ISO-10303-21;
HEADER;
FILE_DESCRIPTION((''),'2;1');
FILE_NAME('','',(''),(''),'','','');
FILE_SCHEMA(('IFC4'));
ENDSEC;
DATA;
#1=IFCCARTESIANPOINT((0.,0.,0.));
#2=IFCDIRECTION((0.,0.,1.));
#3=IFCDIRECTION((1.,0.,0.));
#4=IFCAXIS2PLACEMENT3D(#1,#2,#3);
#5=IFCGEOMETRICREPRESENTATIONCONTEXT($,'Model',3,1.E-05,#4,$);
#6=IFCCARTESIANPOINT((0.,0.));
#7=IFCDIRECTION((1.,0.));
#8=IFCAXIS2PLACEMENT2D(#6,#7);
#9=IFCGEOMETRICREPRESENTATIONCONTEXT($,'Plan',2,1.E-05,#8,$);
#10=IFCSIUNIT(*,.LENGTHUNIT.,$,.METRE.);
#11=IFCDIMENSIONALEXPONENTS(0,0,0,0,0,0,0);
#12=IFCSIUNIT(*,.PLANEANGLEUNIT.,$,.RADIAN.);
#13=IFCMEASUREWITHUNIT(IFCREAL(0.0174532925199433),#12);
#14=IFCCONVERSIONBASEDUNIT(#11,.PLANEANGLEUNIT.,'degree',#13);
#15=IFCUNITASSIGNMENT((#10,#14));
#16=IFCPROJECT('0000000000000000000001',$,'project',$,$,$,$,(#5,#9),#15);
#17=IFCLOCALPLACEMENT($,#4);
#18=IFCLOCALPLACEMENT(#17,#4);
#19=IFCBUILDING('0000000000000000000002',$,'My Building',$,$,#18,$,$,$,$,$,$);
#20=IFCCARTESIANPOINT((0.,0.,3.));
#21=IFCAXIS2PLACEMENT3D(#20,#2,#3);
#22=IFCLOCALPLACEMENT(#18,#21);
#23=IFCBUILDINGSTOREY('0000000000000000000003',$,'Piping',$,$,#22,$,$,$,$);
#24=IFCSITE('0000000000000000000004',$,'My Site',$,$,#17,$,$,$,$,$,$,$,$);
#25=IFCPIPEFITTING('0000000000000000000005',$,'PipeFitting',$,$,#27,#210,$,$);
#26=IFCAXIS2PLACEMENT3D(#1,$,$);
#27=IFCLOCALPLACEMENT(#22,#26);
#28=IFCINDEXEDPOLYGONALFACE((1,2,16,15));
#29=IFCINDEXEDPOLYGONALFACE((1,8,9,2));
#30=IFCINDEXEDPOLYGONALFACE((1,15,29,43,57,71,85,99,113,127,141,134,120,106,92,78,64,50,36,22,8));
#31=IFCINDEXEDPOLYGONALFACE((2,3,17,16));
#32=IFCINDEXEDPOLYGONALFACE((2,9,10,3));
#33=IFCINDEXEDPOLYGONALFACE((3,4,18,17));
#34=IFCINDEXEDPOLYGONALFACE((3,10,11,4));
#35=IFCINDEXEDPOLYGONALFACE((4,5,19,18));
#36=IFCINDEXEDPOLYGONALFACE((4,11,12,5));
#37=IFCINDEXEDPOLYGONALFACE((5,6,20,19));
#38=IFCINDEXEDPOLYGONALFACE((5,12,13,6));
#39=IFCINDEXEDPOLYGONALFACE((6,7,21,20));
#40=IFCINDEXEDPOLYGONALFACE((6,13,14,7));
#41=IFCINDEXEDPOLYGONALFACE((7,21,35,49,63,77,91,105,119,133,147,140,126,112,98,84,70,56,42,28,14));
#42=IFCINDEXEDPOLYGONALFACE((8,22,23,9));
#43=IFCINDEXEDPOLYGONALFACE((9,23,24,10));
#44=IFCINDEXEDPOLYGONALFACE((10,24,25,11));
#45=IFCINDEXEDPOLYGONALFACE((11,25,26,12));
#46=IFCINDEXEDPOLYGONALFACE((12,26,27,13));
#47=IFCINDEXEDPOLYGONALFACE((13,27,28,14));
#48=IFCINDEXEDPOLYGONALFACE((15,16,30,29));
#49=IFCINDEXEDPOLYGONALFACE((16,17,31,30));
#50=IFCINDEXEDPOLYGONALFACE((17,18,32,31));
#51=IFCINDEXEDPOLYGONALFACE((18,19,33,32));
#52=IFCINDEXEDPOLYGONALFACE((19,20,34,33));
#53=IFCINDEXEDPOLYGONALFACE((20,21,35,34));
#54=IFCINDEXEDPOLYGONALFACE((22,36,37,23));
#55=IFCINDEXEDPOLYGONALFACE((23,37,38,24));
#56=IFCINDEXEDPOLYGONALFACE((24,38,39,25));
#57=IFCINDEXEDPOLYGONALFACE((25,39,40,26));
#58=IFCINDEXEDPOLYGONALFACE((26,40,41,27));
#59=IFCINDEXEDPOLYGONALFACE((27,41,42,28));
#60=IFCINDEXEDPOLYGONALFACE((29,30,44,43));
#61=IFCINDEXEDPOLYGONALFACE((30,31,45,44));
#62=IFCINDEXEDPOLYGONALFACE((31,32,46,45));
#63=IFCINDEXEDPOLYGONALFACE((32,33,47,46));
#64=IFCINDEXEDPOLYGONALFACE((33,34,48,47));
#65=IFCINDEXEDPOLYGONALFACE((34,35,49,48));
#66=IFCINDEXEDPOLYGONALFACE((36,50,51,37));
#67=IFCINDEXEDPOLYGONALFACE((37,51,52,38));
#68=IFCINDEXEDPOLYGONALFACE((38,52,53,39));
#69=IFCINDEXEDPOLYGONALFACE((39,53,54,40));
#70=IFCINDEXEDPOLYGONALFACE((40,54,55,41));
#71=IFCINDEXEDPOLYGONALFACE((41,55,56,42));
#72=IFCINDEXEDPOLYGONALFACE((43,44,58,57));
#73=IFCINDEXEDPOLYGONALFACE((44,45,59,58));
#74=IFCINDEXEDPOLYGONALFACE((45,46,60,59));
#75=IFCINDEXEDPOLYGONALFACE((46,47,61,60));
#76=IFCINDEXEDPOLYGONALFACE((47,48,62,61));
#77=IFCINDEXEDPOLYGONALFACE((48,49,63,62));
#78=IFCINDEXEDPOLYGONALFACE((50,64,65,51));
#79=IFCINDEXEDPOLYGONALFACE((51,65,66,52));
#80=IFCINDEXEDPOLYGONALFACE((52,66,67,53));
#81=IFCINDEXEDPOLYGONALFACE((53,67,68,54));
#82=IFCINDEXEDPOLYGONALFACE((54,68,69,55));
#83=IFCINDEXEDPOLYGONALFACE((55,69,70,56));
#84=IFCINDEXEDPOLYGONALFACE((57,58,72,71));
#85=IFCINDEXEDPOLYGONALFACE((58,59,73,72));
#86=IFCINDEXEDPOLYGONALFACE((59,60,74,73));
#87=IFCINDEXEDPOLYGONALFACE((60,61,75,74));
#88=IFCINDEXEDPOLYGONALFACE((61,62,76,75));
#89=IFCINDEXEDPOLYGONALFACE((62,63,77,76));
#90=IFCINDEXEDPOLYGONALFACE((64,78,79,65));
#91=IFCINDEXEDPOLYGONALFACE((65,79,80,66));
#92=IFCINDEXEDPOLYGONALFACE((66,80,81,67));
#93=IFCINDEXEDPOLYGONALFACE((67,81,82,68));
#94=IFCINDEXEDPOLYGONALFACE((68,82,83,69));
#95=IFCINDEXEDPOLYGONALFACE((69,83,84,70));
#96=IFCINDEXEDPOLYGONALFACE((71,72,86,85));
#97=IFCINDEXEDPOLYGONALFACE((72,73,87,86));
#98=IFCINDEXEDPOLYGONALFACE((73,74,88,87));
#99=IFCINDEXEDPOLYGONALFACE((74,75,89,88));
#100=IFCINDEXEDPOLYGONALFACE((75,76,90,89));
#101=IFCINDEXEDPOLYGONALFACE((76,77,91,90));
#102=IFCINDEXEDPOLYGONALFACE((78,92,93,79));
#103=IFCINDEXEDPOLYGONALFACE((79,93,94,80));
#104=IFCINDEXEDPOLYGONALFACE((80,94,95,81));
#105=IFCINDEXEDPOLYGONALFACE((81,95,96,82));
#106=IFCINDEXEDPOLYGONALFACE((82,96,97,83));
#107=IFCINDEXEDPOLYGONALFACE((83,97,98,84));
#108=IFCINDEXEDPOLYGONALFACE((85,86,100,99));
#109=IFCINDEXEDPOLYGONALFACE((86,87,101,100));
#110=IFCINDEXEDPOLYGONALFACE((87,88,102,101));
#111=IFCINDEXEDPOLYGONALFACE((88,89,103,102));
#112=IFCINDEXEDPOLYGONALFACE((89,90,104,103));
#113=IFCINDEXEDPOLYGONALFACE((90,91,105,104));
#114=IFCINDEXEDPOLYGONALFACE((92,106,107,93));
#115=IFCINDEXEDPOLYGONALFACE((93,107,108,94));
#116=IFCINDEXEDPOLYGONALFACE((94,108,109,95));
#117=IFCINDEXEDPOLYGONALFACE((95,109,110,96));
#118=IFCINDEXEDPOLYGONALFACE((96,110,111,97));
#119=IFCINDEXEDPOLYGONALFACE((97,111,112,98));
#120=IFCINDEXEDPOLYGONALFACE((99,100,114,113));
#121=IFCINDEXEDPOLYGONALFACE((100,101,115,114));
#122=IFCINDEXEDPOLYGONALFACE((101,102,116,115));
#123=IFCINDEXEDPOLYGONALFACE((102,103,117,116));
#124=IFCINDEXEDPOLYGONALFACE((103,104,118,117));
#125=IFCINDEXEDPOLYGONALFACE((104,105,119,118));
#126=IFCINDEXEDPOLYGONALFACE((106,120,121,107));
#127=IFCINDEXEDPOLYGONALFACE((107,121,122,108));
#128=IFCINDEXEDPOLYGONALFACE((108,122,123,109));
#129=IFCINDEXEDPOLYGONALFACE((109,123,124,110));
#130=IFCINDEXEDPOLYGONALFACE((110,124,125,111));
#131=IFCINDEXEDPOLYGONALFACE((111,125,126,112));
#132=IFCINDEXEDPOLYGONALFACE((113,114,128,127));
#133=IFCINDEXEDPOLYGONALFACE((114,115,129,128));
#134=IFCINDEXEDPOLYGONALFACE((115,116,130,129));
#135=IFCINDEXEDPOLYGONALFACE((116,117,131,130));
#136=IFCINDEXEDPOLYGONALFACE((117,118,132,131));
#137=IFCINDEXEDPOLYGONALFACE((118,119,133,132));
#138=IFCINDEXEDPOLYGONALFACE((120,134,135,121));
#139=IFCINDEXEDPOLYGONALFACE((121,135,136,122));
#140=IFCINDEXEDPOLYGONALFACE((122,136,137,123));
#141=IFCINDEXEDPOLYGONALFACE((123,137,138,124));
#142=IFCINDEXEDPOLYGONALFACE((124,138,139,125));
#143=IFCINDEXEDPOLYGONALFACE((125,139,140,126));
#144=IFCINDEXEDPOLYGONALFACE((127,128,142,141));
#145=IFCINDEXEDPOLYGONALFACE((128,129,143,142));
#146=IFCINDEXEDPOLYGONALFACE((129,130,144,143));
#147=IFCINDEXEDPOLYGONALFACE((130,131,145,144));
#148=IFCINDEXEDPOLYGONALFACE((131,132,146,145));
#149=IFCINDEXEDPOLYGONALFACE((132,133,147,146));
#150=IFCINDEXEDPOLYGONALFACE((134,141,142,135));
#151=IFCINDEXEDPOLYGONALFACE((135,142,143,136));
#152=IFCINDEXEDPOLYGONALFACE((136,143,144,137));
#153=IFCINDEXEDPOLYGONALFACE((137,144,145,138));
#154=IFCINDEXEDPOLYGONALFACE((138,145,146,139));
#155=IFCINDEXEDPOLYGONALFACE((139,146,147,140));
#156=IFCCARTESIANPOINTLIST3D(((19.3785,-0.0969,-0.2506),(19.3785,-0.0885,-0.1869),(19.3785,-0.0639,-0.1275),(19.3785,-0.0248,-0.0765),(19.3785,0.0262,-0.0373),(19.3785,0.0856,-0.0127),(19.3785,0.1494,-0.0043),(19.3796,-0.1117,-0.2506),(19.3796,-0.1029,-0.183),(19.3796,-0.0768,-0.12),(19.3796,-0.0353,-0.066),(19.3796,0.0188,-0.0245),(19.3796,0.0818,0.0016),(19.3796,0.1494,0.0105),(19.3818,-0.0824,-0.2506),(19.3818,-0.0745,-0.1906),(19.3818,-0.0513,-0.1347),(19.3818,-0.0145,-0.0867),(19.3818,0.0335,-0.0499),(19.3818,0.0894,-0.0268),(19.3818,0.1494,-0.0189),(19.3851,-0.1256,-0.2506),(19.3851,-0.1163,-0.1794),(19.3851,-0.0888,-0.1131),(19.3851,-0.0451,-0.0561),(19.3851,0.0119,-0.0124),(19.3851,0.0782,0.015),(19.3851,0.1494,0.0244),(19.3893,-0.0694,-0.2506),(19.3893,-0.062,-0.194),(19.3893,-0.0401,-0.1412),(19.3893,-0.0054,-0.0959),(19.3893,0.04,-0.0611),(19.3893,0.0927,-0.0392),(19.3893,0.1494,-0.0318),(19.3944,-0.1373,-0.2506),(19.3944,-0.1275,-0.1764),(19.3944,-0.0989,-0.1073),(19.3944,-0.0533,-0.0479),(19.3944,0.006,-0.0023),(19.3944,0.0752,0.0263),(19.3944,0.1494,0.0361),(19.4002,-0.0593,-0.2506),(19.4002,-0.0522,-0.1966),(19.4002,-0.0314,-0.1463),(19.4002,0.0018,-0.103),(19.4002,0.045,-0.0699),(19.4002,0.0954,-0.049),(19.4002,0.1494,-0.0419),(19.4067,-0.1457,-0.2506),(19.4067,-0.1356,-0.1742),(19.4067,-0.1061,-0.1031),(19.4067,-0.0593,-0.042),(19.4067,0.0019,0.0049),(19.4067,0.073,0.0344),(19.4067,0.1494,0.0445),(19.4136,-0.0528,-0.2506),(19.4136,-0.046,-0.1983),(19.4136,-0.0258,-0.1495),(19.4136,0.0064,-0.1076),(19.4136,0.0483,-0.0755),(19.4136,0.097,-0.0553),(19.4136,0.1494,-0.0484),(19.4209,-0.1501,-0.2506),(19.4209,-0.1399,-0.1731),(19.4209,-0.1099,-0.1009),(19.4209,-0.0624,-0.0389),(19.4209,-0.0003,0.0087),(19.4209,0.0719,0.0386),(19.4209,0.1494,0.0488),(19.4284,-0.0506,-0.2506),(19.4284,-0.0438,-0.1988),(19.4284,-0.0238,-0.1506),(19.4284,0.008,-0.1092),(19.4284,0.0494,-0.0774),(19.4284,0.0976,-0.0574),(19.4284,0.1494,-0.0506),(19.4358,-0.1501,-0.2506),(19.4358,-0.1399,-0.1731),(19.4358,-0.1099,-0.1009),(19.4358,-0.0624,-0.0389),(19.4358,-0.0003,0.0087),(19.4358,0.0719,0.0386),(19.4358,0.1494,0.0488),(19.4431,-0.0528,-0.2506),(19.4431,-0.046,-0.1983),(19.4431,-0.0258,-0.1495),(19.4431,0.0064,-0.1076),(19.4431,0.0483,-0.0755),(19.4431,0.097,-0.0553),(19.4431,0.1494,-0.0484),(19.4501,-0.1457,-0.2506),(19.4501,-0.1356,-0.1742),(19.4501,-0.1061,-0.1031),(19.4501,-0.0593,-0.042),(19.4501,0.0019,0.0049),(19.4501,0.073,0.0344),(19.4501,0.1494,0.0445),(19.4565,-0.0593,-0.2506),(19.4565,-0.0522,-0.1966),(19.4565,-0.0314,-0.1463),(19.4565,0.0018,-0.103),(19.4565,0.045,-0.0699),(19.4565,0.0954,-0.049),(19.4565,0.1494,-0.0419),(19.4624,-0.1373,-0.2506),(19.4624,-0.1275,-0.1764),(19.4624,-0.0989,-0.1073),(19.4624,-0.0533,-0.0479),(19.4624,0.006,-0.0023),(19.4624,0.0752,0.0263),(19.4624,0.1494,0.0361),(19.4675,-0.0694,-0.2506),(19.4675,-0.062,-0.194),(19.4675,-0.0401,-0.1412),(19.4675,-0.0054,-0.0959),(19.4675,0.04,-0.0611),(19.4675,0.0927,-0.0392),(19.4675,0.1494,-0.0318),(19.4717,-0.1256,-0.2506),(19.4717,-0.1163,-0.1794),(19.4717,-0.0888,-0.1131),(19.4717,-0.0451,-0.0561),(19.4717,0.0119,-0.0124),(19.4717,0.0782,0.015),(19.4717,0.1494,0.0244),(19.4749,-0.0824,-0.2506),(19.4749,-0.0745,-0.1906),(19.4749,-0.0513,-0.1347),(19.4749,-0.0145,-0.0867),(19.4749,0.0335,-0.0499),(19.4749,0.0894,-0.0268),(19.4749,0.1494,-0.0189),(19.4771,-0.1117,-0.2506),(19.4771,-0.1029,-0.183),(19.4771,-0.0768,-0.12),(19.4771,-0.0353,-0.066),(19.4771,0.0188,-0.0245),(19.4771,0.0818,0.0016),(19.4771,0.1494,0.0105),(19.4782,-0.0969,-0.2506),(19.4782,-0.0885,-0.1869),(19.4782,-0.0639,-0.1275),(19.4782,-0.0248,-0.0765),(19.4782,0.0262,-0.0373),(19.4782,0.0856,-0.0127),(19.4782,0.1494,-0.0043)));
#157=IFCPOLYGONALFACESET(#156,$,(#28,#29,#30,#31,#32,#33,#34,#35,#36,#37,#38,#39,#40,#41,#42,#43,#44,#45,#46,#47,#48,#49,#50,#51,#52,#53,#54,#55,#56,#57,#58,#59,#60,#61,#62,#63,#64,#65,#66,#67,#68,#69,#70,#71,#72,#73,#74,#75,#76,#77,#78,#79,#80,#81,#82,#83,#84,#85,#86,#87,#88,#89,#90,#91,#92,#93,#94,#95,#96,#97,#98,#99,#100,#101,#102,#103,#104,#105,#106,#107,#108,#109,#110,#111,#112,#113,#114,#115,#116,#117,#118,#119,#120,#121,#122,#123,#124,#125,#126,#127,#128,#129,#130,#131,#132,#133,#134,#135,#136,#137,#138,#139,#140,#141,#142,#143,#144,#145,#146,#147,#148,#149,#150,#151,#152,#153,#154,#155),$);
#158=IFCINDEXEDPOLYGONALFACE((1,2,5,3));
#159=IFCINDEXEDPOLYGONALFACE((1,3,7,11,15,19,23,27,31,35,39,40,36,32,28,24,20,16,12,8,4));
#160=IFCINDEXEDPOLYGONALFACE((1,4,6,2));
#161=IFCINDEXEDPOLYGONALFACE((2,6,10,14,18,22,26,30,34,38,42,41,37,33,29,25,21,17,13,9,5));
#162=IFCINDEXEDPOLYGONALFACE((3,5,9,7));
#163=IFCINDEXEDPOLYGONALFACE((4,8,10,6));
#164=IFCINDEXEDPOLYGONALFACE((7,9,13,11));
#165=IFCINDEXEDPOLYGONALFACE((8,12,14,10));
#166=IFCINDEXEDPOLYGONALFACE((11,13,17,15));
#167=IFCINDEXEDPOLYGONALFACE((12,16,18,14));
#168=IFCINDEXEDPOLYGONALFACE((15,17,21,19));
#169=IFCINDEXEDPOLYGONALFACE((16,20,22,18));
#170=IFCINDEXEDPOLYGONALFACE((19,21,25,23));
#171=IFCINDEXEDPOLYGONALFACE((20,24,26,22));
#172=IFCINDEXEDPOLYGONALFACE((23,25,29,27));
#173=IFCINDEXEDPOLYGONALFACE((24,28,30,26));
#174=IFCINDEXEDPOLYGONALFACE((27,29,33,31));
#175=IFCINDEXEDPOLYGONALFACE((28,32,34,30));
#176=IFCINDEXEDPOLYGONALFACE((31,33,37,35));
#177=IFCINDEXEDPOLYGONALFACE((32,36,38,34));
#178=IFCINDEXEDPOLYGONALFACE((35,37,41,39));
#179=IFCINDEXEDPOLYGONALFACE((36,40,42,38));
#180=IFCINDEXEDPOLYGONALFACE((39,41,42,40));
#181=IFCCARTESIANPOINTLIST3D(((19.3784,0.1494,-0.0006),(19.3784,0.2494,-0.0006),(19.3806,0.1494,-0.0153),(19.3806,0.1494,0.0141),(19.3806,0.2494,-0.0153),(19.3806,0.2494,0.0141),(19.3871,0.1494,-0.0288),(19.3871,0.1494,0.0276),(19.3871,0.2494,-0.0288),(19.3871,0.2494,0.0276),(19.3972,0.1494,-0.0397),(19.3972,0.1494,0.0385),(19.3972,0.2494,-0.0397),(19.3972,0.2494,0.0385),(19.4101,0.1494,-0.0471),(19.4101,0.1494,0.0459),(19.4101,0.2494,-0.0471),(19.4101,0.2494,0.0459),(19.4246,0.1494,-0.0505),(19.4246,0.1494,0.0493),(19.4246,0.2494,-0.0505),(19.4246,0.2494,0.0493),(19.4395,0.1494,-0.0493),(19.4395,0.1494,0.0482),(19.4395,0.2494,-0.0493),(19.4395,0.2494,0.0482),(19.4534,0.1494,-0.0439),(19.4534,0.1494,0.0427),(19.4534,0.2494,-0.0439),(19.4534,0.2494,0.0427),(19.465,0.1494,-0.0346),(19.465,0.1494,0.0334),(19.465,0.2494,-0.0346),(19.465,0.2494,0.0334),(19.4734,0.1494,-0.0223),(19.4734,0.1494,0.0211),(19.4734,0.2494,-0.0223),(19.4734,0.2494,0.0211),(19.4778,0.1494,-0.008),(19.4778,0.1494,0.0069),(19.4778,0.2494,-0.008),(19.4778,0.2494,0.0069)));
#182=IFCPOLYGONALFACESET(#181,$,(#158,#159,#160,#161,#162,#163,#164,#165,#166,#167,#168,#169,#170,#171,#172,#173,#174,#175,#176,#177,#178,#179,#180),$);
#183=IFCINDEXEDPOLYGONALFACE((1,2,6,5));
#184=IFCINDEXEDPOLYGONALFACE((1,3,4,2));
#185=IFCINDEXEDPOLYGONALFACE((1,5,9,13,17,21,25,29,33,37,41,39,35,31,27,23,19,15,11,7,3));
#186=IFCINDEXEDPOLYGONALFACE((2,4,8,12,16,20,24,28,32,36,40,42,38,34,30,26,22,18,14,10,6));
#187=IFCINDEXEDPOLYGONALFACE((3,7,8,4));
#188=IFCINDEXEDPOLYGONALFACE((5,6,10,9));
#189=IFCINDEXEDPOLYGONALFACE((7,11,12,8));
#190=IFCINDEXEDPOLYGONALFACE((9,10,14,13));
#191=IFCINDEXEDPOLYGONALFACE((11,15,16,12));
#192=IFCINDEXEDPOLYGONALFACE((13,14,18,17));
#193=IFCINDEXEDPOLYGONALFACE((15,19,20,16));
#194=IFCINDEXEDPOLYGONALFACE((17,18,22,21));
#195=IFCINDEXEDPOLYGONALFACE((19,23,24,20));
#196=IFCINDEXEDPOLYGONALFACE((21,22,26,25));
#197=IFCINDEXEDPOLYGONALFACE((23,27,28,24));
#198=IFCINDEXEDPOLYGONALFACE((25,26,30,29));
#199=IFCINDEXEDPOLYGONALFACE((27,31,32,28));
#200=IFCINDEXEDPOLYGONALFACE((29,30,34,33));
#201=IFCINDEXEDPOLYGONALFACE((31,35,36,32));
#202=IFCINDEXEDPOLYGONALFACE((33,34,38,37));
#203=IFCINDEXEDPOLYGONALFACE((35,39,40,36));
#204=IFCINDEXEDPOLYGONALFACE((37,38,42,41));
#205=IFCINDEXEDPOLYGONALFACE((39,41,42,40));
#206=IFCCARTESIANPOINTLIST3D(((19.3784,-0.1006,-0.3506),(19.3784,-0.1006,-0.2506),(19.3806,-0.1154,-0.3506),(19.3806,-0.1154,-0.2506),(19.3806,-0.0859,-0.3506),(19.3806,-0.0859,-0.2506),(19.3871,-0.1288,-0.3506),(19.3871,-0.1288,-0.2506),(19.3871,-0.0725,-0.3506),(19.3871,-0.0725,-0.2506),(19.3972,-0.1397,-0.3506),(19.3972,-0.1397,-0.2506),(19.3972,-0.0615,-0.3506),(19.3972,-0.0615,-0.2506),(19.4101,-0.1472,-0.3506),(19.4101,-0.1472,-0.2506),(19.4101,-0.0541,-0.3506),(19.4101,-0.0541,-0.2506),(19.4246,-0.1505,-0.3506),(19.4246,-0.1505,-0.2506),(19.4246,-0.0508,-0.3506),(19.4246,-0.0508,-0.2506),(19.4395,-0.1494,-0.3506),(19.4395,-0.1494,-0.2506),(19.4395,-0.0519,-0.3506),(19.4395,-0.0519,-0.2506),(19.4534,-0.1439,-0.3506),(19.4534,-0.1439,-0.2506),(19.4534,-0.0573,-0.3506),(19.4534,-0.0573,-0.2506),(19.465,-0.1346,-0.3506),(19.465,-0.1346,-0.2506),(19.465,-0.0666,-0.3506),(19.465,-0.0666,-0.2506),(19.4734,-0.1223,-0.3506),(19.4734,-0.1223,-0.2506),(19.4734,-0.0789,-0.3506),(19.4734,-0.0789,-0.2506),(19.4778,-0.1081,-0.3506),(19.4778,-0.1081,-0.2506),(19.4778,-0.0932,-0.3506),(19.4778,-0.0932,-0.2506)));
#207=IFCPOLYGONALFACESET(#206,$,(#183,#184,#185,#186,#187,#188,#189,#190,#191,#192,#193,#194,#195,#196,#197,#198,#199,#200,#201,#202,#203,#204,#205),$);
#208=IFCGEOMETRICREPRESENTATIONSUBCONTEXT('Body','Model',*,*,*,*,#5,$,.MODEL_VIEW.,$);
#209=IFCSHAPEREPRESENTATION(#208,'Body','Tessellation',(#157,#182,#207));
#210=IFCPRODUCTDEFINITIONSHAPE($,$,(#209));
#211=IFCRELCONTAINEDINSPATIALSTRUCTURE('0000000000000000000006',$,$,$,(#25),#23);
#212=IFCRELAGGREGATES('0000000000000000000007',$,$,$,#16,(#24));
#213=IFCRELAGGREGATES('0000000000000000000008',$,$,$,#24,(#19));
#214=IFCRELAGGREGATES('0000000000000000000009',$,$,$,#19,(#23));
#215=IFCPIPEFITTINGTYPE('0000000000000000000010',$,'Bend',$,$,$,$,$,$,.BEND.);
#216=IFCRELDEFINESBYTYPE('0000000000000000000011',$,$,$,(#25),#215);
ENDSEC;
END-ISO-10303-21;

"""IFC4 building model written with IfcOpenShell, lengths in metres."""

from ifc_helpers import new_model, entity, si_unit, converted_unit, frame, origin_with_axes, origin_2d_with_axis, place, context, subcontext, project, spatial, circle, extrude, source, transform, mapped, type_object, type_shapes, element, save


model = new_model("IFC4")

# Units and contexts
model_context = context("Model", 3, precision=1e-05, world=origin_with_axes())
plan_context = context("Plan", 2, precision=1e-05, world=origin_2d_with_axis())
body_context = subcontext(model_context, "Body", "Model", "MODEL_VIEW")
ifc_project = project(units=[si_unit("LENGTHUNIT", "METRE"), converted_unit("PLANEANGLEUNIT", "degree", entity("IfcReal", 0.0174532925199433), si_unit("PLANEANGLEUNIT", "RADIAN"), dimensions=[0, 0, 0, 0, 0, 0, 0])], contexts=[model_context, plan_context])

# Site, building, storey
site_placement = place(None, origin_with_axes())
site = spatial("IfcSite", under=ifc_project, at=site_placement, Name="My Site")
building_placement = place(site_placement, origin_with_axes())
building = spatial("IfcBuilding", under=site, at=building_placement, Name="My Building")
storey_placement = place(building_placement, frame((0.0, 0.0, 3.0), z_axis=(0.0, 0.0, 1.0), x_axis=(1.0, 0.0, 0.0)))
storey = spatial("IfcBuildingStorey", under=building, at=storey_placement, Name="Piping")

# Pipe fitting
pipe_fitting_type = type_object("IfcPipeFittingType", Name="Bend", PredefinedType="BEND")
shared_shape = source(origin_with_axes(), body_context, "Body", "SolidModel", [
    entity("IfcSweptDiskSolid", entity("IfcIndexedPolyCurve", entity("IfcCartesianPointList3D", [[0.0, 0.0, -0.1], [0.0, -0.0732, -0.2768], [0.0, -0.25, -0.35]]), [entity("IfcArcIndex", [1, 2, 3])]), 0.05),
    extrude(circle(Radius=0.05), origin_with_axes(), (0.0, 0.0, -1.0), 0.1),
    extrude(circle(Radius=0.05), frame((0.0, -0.25, -0.35), z_axis=(0.0, -1.0, 0.0), x_axis=(1.0, 0.0, 0.0)), (0.0, 0.0, 1.0), 0.1),
])
type_shapes(pipe_fitting_type, [shared_shape])
for number, where, z_axis, x_axis, name in (
    (1, (19.4284, 0.2494, -0.0006), (0.0, 1.0, 0.0), (-1.0, 0.0, 0.0), "PipeFitting"),
):
    element("IfcPipeFitting", number, at=place(storey_placement, frame(where, z_axis=z_axis, x_axis=x_axis)), inside=storey, type_object=pipe_fitting_type, Name=name, context=body_context, shape_type="MappedRepresentation", body=[
        mapped(shared_shape, transform((0.0, 0.0, 0.0), x_axis=(1.0, 0.0, 0.0), y_axis=(0.0, 1.0, 0.0), z_axis=(0.0, 0.0, 1.0), scale=1.0)),
    ])

save(model, "model.ifc")
